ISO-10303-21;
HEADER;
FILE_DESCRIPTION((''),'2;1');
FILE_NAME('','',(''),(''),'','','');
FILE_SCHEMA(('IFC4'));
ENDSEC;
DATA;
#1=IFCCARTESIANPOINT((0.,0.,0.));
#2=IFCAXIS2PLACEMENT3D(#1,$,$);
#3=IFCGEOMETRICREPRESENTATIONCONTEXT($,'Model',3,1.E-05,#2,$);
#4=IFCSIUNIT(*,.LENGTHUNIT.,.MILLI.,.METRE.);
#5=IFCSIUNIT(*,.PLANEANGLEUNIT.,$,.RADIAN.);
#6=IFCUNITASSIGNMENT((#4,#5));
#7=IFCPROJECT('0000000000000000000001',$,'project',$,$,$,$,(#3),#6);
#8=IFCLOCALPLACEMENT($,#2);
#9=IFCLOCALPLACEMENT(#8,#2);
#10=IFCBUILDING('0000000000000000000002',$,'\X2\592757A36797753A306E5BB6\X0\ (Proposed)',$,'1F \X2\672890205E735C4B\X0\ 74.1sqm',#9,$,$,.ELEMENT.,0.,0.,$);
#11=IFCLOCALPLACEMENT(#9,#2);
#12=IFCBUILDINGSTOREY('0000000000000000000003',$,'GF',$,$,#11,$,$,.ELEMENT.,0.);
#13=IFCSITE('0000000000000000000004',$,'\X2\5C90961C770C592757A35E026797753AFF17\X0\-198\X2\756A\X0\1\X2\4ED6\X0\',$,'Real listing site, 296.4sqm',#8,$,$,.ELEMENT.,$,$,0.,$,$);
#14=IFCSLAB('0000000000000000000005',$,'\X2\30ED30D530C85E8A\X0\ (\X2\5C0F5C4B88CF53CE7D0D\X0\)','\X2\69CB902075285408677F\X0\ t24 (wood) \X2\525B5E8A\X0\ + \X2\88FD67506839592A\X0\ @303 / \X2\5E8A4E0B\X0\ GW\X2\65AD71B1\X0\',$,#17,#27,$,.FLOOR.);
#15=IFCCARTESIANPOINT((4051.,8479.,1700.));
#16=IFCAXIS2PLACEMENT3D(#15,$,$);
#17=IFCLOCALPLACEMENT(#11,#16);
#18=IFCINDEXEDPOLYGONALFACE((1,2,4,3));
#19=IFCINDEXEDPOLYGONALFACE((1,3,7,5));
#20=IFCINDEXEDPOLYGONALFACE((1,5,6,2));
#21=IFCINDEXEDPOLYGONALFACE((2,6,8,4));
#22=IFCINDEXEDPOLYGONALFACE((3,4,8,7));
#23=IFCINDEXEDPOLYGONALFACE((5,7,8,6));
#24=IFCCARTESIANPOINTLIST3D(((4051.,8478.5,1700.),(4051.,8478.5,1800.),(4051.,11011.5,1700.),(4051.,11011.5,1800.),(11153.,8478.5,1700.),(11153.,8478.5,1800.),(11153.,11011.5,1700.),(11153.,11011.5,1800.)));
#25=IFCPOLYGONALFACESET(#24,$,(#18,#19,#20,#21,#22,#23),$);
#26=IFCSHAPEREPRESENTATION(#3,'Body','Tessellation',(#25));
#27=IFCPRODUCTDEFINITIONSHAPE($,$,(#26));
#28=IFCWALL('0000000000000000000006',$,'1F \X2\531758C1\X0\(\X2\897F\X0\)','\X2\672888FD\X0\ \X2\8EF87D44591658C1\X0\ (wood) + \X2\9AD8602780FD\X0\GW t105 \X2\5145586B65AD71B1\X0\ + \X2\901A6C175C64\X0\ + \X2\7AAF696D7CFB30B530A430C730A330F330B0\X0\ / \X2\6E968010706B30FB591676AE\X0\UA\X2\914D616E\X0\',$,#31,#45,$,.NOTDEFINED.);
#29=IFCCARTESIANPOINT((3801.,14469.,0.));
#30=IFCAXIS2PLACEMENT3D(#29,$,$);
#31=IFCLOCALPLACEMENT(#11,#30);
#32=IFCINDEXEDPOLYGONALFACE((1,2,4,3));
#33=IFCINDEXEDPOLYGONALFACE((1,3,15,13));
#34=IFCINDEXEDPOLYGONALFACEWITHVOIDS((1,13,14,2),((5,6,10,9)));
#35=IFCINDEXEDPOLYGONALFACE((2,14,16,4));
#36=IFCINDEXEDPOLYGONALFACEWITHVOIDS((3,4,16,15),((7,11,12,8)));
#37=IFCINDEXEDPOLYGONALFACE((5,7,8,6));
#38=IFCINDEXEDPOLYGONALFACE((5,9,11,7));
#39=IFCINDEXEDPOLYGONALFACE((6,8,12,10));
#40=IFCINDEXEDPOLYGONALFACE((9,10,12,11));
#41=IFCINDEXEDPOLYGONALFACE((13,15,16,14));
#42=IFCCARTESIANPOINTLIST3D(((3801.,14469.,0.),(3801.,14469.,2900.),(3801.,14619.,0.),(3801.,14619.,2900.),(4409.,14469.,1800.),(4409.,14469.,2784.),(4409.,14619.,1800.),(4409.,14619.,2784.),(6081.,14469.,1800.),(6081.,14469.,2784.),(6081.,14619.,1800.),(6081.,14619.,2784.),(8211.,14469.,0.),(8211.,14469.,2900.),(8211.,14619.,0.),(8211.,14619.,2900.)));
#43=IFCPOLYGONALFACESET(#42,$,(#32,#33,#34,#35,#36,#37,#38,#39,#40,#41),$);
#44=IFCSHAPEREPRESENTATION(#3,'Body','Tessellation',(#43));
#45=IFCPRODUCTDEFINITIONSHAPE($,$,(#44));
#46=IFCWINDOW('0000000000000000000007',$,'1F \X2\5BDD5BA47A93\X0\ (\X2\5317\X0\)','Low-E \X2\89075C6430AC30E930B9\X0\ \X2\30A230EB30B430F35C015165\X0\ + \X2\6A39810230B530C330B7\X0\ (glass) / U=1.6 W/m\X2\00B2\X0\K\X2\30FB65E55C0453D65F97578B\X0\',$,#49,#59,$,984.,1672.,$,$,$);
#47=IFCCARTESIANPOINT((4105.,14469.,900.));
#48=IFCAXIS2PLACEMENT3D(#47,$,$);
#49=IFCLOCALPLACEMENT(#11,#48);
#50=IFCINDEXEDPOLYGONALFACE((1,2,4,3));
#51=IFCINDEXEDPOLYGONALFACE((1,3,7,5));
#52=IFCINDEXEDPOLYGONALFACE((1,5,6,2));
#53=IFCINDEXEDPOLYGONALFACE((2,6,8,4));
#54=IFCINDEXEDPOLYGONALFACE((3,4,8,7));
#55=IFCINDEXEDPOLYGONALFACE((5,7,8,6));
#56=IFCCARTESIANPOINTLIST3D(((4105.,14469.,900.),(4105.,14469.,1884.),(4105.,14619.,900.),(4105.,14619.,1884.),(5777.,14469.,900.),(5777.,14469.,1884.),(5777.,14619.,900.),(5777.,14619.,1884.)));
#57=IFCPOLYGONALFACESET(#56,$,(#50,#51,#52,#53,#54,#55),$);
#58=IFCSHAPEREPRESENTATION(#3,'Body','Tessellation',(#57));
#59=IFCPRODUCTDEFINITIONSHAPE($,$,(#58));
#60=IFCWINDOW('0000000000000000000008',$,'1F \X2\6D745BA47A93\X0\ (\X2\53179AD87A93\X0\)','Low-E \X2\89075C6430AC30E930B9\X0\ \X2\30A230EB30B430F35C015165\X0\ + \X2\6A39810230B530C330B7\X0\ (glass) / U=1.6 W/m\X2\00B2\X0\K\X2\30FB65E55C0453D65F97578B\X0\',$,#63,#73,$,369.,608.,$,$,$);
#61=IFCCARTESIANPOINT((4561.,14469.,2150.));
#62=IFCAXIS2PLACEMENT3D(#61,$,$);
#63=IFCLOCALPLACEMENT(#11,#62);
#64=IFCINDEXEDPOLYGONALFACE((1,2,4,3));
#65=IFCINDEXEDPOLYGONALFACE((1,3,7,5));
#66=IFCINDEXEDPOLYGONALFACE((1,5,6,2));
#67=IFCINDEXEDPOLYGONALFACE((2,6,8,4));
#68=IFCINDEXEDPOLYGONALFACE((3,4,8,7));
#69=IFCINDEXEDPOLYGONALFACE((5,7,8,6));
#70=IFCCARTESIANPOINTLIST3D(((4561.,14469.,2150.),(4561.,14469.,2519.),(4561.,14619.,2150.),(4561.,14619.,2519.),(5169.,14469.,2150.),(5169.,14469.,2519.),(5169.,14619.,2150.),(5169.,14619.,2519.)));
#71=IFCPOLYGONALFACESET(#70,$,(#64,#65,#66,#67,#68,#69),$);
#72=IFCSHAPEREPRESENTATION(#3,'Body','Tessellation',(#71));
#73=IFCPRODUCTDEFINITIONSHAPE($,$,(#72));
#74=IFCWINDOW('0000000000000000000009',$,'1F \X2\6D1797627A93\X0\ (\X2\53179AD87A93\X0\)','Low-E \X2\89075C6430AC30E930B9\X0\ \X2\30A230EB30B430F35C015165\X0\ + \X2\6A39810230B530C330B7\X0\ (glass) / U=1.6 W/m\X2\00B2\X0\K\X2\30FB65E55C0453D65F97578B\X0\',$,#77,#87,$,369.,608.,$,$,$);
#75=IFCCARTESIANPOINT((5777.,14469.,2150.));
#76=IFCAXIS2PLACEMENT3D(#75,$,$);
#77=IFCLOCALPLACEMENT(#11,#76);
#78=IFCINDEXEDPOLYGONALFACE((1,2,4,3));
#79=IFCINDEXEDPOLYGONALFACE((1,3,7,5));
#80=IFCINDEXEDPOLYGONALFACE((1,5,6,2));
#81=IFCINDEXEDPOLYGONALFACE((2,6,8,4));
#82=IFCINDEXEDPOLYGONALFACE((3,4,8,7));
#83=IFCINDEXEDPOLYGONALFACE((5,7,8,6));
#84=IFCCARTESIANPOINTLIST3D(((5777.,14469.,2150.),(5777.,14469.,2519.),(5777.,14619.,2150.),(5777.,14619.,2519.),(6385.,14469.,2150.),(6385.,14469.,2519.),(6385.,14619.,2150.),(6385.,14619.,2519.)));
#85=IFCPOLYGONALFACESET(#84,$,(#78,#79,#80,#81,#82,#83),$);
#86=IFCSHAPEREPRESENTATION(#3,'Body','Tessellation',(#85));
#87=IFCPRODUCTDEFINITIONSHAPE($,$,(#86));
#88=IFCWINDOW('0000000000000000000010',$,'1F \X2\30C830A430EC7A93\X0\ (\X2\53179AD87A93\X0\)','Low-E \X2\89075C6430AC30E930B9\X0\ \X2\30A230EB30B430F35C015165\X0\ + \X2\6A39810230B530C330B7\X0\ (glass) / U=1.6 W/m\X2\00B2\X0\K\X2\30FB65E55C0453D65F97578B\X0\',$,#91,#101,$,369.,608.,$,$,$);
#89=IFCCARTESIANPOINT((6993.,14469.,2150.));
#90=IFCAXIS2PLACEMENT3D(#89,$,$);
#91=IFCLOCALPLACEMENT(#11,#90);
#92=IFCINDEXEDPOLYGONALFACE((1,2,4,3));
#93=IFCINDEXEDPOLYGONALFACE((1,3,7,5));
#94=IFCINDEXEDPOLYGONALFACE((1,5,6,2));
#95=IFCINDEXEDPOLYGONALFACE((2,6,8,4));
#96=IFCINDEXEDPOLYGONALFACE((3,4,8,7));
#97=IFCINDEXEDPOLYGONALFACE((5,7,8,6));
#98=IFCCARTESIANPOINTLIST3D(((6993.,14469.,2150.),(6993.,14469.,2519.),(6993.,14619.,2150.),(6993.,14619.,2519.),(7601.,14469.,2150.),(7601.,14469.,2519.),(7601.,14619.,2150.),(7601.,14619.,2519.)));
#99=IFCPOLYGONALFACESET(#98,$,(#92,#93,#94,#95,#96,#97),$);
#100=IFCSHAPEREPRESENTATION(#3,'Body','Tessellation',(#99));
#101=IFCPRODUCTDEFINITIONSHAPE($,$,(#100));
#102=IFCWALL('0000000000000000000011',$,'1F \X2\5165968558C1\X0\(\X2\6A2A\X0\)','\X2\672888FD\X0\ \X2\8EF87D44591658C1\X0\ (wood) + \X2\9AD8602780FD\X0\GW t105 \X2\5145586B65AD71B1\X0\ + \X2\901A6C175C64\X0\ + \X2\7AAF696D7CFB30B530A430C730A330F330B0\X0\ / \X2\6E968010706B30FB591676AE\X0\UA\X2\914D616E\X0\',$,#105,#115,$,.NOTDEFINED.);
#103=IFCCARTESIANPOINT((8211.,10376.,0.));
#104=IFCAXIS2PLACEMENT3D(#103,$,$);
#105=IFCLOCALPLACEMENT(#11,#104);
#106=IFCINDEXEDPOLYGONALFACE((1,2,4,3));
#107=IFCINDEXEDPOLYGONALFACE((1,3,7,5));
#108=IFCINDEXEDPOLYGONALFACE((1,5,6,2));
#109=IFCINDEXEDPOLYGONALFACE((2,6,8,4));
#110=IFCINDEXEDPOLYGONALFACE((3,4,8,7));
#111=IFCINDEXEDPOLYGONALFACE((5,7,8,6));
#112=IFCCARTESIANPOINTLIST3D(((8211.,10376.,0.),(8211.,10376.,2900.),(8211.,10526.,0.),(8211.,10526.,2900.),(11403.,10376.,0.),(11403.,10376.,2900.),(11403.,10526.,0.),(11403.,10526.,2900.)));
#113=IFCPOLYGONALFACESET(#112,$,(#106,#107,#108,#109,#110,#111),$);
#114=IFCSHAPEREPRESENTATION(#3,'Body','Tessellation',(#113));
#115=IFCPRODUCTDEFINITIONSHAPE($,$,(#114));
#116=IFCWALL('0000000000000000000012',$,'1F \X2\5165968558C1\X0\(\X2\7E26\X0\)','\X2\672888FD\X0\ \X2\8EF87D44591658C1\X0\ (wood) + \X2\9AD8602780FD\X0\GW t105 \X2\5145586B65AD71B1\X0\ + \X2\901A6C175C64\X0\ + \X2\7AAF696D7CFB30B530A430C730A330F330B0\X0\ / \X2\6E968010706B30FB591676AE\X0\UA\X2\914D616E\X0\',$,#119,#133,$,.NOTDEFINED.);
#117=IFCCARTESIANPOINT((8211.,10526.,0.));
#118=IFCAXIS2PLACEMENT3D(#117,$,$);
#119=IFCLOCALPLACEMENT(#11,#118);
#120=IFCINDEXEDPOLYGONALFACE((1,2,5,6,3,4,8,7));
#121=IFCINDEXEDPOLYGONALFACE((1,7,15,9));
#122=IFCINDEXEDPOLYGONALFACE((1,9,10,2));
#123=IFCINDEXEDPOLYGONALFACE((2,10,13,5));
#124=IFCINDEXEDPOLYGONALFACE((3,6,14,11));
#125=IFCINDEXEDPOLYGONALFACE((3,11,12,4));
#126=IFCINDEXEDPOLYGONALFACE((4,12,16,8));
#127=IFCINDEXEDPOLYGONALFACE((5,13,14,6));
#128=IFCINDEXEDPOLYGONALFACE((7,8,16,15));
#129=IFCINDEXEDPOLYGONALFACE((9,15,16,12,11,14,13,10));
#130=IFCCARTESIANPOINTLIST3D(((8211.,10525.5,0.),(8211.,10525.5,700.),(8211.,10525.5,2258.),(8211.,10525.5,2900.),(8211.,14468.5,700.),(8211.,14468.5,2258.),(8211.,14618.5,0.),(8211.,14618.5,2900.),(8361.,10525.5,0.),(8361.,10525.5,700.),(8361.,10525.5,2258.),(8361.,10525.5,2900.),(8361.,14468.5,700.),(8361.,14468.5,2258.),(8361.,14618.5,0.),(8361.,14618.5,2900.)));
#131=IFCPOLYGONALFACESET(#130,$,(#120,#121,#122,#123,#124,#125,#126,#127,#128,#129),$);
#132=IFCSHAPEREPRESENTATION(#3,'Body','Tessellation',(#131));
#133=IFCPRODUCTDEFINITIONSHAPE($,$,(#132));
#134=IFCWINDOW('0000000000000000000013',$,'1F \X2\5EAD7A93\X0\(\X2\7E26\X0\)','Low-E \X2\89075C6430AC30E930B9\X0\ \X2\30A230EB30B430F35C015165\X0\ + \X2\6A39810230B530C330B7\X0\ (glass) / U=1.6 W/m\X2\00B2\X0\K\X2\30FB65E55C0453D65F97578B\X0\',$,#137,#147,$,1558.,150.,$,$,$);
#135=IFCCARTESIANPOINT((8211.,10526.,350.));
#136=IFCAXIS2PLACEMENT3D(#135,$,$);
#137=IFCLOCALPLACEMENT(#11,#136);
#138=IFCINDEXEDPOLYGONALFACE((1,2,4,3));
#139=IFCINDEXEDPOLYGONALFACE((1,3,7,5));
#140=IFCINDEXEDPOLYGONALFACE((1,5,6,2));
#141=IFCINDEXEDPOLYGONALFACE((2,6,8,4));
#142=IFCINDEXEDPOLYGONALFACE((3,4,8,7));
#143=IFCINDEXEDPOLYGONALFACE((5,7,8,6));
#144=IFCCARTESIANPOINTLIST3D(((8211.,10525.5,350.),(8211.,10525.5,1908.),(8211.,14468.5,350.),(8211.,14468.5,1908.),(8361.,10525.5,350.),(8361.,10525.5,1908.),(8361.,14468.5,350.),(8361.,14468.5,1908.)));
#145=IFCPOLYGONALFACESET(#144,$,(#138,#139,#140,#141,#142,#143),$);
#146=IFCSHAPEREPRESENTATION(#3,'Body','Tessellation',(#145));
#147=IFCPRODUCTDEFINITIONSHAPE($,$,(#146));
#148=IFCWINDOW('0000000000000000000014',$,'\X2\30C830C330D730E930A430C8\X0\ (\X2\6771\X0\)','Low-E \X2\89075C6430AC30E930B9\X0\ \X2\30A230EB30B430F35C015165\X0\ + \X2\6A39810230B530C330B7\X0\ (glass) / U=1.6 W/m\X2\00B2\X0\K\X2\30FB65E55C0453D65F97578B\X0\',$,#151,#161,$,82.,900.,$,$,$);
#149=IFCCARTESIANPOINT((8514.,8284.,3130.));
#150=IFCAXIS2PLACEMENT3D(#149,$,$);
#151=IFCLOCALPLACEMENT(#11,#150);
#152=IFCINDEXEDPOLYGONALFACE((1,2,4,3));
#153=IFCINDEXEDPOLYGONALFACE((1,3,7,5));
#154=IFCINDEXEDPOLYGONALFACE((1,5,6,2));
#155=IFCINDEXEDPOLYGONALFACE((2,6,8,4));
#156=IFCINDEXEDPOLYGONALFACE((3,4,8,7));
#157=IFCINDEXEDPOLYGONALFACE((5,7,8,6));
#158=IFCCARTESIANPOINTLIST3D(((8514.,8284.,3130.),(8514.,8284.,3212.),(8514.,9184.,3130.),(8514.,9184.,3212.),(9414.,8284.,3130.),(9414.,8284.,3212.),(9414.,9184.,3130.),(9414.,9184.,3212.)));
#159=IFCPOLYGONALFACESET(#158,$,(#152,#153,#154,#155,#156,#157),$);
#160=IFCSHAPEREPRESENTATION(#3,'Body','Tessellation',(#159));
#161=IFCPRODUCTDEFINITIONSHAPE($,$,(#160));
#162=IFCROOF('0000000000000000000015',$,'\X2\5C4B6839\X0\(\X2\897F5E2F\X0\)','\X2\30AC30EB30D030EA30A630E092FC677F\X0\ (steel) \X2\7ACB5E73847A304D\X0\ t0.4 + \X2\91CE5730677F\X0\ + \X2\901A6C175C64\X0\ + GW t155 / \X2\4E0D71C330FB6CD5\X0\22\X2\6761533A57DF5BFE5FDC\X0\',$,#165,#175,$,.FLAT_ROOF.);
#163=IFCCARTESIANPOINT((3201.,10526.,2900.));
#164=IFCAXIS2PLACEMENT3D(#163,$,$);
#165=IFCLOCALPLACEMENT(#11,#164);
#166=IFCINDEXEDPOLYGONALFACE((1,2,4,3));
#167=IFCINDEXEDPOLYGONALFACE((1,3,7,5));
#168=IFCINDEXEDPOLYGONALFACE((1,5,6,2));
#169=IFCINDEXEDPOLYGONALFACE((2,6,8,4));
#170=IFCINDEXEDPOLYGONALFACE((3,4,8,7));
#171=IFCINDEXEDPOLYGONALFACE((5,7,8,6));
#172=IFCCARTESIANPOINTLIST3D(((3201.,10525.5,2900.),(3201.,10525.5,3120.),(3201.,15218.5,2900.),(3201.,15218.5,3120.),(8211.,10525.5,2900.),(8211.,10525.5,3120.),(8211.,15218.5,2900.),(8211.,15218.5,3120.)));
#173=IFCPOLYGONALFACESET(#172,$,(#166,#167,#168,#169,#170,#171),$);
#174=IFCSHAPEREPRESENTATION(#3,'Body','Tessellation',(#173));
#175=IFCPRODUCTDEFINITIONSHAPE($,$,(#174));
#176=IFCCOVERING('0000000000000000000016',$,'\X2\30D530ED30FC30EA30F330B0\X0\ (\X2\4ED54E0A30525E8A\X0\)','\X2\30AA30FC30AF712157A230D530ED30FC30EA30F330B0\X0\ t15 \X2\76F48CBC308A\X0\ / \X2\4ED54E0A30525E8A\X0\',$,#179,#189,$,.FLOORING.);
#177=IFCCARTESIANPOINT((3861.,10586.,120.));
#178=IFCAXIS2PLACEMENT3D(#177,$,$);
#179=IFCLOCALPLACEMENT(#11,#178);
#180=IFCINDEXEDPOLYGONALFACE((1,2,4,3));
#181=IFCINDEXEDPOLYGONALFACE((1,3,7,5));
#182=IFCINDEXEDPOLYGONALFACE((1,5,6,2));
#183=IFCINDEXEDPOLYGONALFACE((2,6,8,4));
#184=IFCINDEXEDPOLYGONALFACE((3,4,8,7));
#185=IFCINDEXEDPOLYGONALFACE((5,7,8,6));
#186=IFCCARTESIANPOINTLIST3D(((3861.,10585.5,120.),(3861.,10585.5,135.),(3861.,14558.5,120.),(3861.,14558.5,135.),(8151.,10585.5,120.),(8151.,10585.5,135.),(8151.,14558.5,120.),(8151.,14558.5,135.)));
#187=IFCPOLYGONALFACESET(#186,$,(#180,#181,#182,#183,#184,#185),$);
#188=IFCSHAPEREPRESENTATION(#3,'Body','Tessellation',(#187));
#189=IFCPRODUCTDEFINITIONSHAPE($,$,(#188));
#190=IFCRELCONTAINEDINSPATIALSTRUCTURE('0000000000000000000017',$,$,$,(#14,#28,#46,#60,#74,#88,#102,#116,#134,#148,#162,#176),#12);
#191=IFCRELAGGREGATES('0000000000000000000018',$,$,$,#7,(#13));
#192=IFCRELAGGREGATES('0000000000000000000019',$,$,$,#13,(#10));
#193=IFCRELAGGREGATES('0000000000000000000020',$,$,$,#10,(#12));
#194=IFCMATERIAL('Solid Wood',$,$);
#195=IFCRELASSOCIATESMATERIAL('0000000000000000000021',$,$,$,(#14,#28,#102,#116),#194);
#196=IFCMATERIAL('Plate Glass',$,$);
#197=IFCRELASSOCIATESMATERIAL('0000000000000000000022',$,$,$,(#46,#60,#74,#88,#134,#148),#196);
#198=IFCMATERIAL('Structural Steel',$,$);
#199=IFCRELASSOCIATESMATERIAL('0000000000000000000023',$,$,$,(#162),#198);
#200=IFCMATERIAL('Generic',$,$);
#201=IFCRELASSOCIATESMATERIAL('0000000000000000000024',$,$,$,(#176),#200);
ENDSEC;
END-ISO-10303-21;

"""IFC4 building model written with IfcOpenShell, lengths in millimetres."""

from ifc_helpers import new_model, si_unit, frame, frame_2d, origin, place, context, project, spatial, rectangle, extrude, material, element, fill, save


model = new_model("IFC4")

# Units and contexts
model_context = context("Model", 3, precision=1e-05, world=origin())
ifc_project = project(units=[si_unit("LENGTHUNIT", "METRE", prefix="MILLI"), si_unit("PLANEANGLEUNIT", "RADIAN")], contexts=[model_context])

# Site, building, storey
site_placement = place(None, origin())
site = spatial("IfcSite", under=ifc_project, at=site_placement, Name="岐阜県大垣市林町７-198番1他", ObjectType="Real listing site, 296.4sqm", CompositionType="ELEMENT", RefElevation=0.0)
building_placement = place(site_placement, origin())
building = spatial("IfcBuilding", under=site, at=building_placement, Name="大垣林町の家 (Proposed)", ObjectType="1F 木造平屋 74.1sqm", CompositionType="ELEMENT", ElevationOfRefHeight=0.0, ElevationOfTerrain=0.0)
storey_placement = place(building_placement, origin())
storey = spatial("IfcBuildingStorey", under=building, at=storey_placement, Name="GF", CompositionType="ELEMENT", Elevation=0.0)

# Slab
ifc_material_1 = material(Name="Solid Wood")
slab_1_placement = place(storey_placement, frame((4051.0, 8479.0, 1700.0)))
element("IfcSlab", 1, at=slab_1_placement, inside=storey, material=ifc_material_1, Name="ロフト床 (小屋裏収納)", Description="構造用合板 t24 (wood) 剛床 + 製材根太 @303 / 床下 GW断熱", PredefinedType="FLOOR", context=model_context, shape_type="SweptSolid", body=[
    extrude(rectangle(XDim=7102.0, YDim=2533.0, at=frame_2d((3551.0, 1266.0))), frame((4051.0, 8479.0, 1700.0)), (0.0, 0.0, 1.0), 100.0),
])

# Wall, openings, windows
wall_1_placement = place(storey_placement, frame((3801.0, 14469.0, 0.0)))
wall_1 = element("IfcWall", 2, at=wall_1_placement, inside=storey, material=ifc_material_1, Name="1F 北壁(西)", Description="木製 軸組外壁 (wood) + 高性能GW t105 充填断熱 + 通気層 + 窯業系サイディング / 準耐火・外皮UA配慮", PredefinedType="NOTDEFINED", context=model_context, shape_type="SweptSolid", body=[
    extrude(rectangle(XDim=4410.0, YDim=150.0, at=frame_2d((2205.0, 75.0))), frame((3801.0, 14469.0, 0.0)), (0.0, 0.0, 1.0), 2900.0),
])
opening_1_placement = place(storey_placement, frame((4105.0, 14469.0, 900.0)))
opening_1 = element("IfcOpeningElement", 3, at=opening_1_placement, cuts=wall_1, PredefinedType="NOTDEFINED", context=model_context, shape_type="SweptSolid", body=[
    extrude(rectangle(XDim=1672.0, YDim=150.0, at=frame_2d((836.0, 75.0))), frame((4105.0, 14469.0, 900.0)), (0.0, 0.0, 1.0), 984.0),
])
opening_2_placement = place(storey_placement, frame((4561.0, 14469.0, 2150.0)))
opening_2 = element("IfcOpeningElement", 4, at=opening_2_placement, cuts=wall_1, PredefinedType="NOTDEFINED", context=model_context, shape_type="SweptSolid", body=[
    extrude(rectangle(XDim=608.0, YDim=150.0, at=frame_2d((304.0, 75.0))), frame((4561.0, 14469.0, 2150.0)), (0.0, 0.0, 1.0), 369.0),
])
opening_3_placement = place(storey_placement, frame((5777.0, 14469.0, 2150.0)))
opening_3 = element("IfcOpeningElement", 5, at=opening_3_placement, cuts=wall_1, PredefinedType="NOTDEFINED", context=model_context, shape_type="SweptSolid", body=[
    extrude(rectangle(XDim=608.0, YDim=150.0, at=frame_2d((304.0, 75.0))), frame((5777.0, 14469.0, 2150.0)), (0.0, 0.0, 1.0), 369.0),
])
opening_4_placement = place(storey_placement, frame((6993.0, 14469.0, 2150.0)))
opening_4 = element("IfcOpeningElement", 6, at=opening_4_placement, cuts=wall_1, PredefinedType="NOTDEFINED", context=model_context, shape_type="SweptSolid", body=[
    extrude(rectangle(XDim=608.0, YDim=150.0, at=frame_2d((304.0, 75.0))), frame((6993.0, 14469.0, 2150.0)), (0.0, 0.0, 1.0), 369.0),
])
ifc_material_2 = material(Name="Plate Glass")
window_1_placement = place(storey_placement, frame((4105.0, 14469.0, 900.0)))
window_1 = element("IfcWindow", 7, at=window_1_placement, inside=storey, material=ifc_material_2, Name="1F 寝室窓 (北)", Description="Low-E 複層ガラス アルゴン封入 + 樹脂サッシ (glass) / U=1.6 W/m²K・日射取得型", OverallHeight=984.0, OverallWidth=1672.0, context=model_context, shape_type="SweptSolid", body=[
    extrude(rectangle(XDim=1672.0, YDim=150.0, at=frame_2d((836.0, 75.0))), frame((4105.0, 14469.0, 900.0)), (0.0, 0.0, 1.0), 984.0),
])
fill(opening_1, window_1)
window_2_placement = place(storey_placement, frame((4561.0, 14469.0, 2150.0)))
window_2 = element("IfcWindow", 8, at=window_2_placement, inside=storey, material=ifc_material_2, Name="1F 浴室窓 (北高窓)", Description="Low-E 複層ガラス アルゴン封入 + 樹脂サッシ (glass) / U=1.6 W/m²K・日射取得型", OverallHeight=369.0, OverallWidth=608.0, context=model_context, shape_type="SweptSolid", body=[
    extrude(rectangle(XDim=608.0, YDim=150.0, at=frame_2d((304.0, 75.0))), frame((4561.0, 14469.0, 2150.0)), (0.0, 0.0, 1.0), 369.0),
])
fill(opening_2, window_2)
window_3_placement = place(storey_placement, frame((5777.0, 14469.0, 2150.0)))
window_3 = element("IfcWindow", 9, at=window_3_placement, inside=storey, material=ifc_material_2, Name="1F 洗面窓 (北高窓)", Description="Low-E 複層ガラス アルゴン封入 + 樹脂サッシ (glass) / U=1.6 W/m²K・日射取得型", OverallHeight=369.0, OverallWidth=608.0, context=model_context, shape_type="SweptSolid", body=[
    extrude(rectangle(XDim=608.0, YDim=150.0, at=frame_2d((304.0, 75.0))), frame((5777.0, 14469.0, 2150.0)), (0.0, 0.0, 1.0), 369.0),
])
fill(opening_3, window_3)
window_4_placement = place(storey_placement, frame((6993.0, 14469.0, 2150.0)))
window_4 = element("IfcWindow", 10, at=window_4_placement, inside=storey, material=ifc_material_2, Name="1F トイレ窓 (北高窓)", Description="Low-E 複層ガラス アルゴン封入 + 樹脂サッシ (glass) / U=1.6 W/m²K・日射取得型", OverallHeight=369.0, OverallWidth=608.0, context=model_context, shape_type="SweptSolid", body=[
    extrude(rectangle(XDim=608.0, YDim=150.0, at=frame_2d((304.0, 75.0))), frame((6993.0, 14469.0, 2150.0)), (0.0, 0.0, 1.0), 369.0),
])
fill(opening_4, window_4)

# Wall
wall_2_placement = place(storey_placement, frame((8211.0, 10376.0, 0.0)))
element("IfcWall", 11, at=wall_2_placement, inside=storey, material=ifc_material_1, Name="1F 入隅壁(横)", Description="木製 軸組外壁 (wood) + 高性能GW t105 充填断熱 + 通気層 + 窯業系サイディング / 準耐火・外皮UA配慮", PredefinedType="NOTDEFINED", context=model_context, shape_type="SweptSolid", body=[
    extrude(rectangle(XDim=3192.0, YDim=150.0, at=frame_2d((1596.0, 75.0))), frame((8211.0, 10376.0, 0.0)), (0.0, 0.0, 1.0), 2900.0),
])

# Wall, opening, window
wall_3_placement = place(storey_placement, frame((8211.0, 10526.0, 0.0)))
wall_3 = element("IfcWall", 12, at=wall_3_placement, inside=storey, material=ifc_material_1, Name="1F 入隅壁(縦)", Description="木製 軸組外壁 (wood) + 高性能GW t105 充填断熱 + 通気層 + 窯業系サイディング / 準耐火・外皮UA配慮", PredefinedType="NOTDEFINED", context=model_context, shape_type="SweptSolid", body=[
    extrude(rectangle(XDim=150.0, YDim=4093.0, at=frame_2d((75.0, 2046.0))), frame((8211.0, 10526.0, 0.0)), (0.0, 0.0, 1.0), 2900.0),
])
opening_5_placement = place(storey_placement, frame((8211.0, 10526.0, 350.0)))
opening_5 = element("IfcOpeningElement", 13, at=opening_5_placement, cuts=wall_3, PredefinedType="NOTDEFINED", context=model_context, shape_type="SweptSolid", body=[
    extrude(rectangle(XDim=150.0, YDim=3943.0, at=frame_2d((75.0, 1971.0))), frame((8211.0, 10526.0, 350.0)), (0.0, 0.0, 1.0), 1558.0),
])
window_5_placement = place(storey_placement, frame((8211.0, 10526.0, 350.0)))
window_5 = element("IfcWindow", 14, at=window_5_placement, inside=storey, material=ifc_material_2, Name="1F 庭窓(縦)", Description="Low-E 複層ガラス アルゴン封入 + 樹脂サッシ (glass) / U=1.6 W/m²K・日射取得型", OverallHeight=1558.0, OverallWidth=150.0, context=model_context, shape_type="SweptSolid", body=[
    extrude(rectangle(XDim=150.0, YDim=3943.0, at=frame_2d((75.0, 1971.0))), frame((8211.0, 10526.0, 350.0)), (0.0, 0.0, 1.0), 1558.0),
])
fill(opening_5, window_5)

# Window
window_6_placement = place(storey_placement, frame((8514.0, 8284.0, 3130.0)))
element("IfcWindow", 15, at=window_6_placement, inside=storey, material=ifc_material_2, Name="トップライト (東)", Description="Low-E 複層ガラス アルゴン封入 + 樹脂サッシ (glass) / U=1.6 W/m²K・日射取得型", OverallHeight=82.0, OverallWidth=900.0, context=model_context, shape_type="SweptSolid", body=[
    extrude(rectangle(XDim=900.0, YDim=900.0, at=frame_2d((450.0, 450.0))), frame((8514.0, 8284.0, 3130.0)), (0.0, 0.0, 1.0), 82.0),
])

# Roof
ifc_material_3 = material(Name="Structural Steel")
roof_placement = place(storey_placement, frame((3201.0, 10526.0, 2900.0)))
element("IfcRoof", 16, at=roof_placement, inside=storey, material=ifc_material_3, Name="屋根(西帯)", Description="ガルバリウム鋼板 (steel) 立平葺き t0.4 + 野地板 + 通気層 + GW t155 / 不燃・法22条区域対応", PredefinedType="FLAT_ROOF", context=model_context, shape_type="SweptSolid", body=[
    extrude(rectangle(XDim=5010.0, YDim=4693.0, at=frame_2d((2505.0, 2346.0))), frame((3201.0, 10526.0, 2900.0)), (0.0, 0.0, 1.0), 220.0),
])

# Covering
ifc_material_4 = material(Name="Generic")
covering_placement = place(storey_placement, frame((3861.0, 10586.0, 120.0)))
element("IfcCovering", 17, at=covering_placement, inside=storey, material=ifc_material_4, Name="フローリング (仕上げ床)", Description="オーク無垢フローリング t15 直貼り / 仕上げ床", PredefinedType="FLOORING", context=model_context, shape_type="SweptSolid", body=[
    extrude(rectangle(XDim=4290.0, YDim=3973.0, at=frame_2d((2145.0, 1986.0))), frame((3861.0, 10586.0, 120.0)), (0.0, 0.0, 1.0), 15.0),
])

save(model, "model.ifc")
